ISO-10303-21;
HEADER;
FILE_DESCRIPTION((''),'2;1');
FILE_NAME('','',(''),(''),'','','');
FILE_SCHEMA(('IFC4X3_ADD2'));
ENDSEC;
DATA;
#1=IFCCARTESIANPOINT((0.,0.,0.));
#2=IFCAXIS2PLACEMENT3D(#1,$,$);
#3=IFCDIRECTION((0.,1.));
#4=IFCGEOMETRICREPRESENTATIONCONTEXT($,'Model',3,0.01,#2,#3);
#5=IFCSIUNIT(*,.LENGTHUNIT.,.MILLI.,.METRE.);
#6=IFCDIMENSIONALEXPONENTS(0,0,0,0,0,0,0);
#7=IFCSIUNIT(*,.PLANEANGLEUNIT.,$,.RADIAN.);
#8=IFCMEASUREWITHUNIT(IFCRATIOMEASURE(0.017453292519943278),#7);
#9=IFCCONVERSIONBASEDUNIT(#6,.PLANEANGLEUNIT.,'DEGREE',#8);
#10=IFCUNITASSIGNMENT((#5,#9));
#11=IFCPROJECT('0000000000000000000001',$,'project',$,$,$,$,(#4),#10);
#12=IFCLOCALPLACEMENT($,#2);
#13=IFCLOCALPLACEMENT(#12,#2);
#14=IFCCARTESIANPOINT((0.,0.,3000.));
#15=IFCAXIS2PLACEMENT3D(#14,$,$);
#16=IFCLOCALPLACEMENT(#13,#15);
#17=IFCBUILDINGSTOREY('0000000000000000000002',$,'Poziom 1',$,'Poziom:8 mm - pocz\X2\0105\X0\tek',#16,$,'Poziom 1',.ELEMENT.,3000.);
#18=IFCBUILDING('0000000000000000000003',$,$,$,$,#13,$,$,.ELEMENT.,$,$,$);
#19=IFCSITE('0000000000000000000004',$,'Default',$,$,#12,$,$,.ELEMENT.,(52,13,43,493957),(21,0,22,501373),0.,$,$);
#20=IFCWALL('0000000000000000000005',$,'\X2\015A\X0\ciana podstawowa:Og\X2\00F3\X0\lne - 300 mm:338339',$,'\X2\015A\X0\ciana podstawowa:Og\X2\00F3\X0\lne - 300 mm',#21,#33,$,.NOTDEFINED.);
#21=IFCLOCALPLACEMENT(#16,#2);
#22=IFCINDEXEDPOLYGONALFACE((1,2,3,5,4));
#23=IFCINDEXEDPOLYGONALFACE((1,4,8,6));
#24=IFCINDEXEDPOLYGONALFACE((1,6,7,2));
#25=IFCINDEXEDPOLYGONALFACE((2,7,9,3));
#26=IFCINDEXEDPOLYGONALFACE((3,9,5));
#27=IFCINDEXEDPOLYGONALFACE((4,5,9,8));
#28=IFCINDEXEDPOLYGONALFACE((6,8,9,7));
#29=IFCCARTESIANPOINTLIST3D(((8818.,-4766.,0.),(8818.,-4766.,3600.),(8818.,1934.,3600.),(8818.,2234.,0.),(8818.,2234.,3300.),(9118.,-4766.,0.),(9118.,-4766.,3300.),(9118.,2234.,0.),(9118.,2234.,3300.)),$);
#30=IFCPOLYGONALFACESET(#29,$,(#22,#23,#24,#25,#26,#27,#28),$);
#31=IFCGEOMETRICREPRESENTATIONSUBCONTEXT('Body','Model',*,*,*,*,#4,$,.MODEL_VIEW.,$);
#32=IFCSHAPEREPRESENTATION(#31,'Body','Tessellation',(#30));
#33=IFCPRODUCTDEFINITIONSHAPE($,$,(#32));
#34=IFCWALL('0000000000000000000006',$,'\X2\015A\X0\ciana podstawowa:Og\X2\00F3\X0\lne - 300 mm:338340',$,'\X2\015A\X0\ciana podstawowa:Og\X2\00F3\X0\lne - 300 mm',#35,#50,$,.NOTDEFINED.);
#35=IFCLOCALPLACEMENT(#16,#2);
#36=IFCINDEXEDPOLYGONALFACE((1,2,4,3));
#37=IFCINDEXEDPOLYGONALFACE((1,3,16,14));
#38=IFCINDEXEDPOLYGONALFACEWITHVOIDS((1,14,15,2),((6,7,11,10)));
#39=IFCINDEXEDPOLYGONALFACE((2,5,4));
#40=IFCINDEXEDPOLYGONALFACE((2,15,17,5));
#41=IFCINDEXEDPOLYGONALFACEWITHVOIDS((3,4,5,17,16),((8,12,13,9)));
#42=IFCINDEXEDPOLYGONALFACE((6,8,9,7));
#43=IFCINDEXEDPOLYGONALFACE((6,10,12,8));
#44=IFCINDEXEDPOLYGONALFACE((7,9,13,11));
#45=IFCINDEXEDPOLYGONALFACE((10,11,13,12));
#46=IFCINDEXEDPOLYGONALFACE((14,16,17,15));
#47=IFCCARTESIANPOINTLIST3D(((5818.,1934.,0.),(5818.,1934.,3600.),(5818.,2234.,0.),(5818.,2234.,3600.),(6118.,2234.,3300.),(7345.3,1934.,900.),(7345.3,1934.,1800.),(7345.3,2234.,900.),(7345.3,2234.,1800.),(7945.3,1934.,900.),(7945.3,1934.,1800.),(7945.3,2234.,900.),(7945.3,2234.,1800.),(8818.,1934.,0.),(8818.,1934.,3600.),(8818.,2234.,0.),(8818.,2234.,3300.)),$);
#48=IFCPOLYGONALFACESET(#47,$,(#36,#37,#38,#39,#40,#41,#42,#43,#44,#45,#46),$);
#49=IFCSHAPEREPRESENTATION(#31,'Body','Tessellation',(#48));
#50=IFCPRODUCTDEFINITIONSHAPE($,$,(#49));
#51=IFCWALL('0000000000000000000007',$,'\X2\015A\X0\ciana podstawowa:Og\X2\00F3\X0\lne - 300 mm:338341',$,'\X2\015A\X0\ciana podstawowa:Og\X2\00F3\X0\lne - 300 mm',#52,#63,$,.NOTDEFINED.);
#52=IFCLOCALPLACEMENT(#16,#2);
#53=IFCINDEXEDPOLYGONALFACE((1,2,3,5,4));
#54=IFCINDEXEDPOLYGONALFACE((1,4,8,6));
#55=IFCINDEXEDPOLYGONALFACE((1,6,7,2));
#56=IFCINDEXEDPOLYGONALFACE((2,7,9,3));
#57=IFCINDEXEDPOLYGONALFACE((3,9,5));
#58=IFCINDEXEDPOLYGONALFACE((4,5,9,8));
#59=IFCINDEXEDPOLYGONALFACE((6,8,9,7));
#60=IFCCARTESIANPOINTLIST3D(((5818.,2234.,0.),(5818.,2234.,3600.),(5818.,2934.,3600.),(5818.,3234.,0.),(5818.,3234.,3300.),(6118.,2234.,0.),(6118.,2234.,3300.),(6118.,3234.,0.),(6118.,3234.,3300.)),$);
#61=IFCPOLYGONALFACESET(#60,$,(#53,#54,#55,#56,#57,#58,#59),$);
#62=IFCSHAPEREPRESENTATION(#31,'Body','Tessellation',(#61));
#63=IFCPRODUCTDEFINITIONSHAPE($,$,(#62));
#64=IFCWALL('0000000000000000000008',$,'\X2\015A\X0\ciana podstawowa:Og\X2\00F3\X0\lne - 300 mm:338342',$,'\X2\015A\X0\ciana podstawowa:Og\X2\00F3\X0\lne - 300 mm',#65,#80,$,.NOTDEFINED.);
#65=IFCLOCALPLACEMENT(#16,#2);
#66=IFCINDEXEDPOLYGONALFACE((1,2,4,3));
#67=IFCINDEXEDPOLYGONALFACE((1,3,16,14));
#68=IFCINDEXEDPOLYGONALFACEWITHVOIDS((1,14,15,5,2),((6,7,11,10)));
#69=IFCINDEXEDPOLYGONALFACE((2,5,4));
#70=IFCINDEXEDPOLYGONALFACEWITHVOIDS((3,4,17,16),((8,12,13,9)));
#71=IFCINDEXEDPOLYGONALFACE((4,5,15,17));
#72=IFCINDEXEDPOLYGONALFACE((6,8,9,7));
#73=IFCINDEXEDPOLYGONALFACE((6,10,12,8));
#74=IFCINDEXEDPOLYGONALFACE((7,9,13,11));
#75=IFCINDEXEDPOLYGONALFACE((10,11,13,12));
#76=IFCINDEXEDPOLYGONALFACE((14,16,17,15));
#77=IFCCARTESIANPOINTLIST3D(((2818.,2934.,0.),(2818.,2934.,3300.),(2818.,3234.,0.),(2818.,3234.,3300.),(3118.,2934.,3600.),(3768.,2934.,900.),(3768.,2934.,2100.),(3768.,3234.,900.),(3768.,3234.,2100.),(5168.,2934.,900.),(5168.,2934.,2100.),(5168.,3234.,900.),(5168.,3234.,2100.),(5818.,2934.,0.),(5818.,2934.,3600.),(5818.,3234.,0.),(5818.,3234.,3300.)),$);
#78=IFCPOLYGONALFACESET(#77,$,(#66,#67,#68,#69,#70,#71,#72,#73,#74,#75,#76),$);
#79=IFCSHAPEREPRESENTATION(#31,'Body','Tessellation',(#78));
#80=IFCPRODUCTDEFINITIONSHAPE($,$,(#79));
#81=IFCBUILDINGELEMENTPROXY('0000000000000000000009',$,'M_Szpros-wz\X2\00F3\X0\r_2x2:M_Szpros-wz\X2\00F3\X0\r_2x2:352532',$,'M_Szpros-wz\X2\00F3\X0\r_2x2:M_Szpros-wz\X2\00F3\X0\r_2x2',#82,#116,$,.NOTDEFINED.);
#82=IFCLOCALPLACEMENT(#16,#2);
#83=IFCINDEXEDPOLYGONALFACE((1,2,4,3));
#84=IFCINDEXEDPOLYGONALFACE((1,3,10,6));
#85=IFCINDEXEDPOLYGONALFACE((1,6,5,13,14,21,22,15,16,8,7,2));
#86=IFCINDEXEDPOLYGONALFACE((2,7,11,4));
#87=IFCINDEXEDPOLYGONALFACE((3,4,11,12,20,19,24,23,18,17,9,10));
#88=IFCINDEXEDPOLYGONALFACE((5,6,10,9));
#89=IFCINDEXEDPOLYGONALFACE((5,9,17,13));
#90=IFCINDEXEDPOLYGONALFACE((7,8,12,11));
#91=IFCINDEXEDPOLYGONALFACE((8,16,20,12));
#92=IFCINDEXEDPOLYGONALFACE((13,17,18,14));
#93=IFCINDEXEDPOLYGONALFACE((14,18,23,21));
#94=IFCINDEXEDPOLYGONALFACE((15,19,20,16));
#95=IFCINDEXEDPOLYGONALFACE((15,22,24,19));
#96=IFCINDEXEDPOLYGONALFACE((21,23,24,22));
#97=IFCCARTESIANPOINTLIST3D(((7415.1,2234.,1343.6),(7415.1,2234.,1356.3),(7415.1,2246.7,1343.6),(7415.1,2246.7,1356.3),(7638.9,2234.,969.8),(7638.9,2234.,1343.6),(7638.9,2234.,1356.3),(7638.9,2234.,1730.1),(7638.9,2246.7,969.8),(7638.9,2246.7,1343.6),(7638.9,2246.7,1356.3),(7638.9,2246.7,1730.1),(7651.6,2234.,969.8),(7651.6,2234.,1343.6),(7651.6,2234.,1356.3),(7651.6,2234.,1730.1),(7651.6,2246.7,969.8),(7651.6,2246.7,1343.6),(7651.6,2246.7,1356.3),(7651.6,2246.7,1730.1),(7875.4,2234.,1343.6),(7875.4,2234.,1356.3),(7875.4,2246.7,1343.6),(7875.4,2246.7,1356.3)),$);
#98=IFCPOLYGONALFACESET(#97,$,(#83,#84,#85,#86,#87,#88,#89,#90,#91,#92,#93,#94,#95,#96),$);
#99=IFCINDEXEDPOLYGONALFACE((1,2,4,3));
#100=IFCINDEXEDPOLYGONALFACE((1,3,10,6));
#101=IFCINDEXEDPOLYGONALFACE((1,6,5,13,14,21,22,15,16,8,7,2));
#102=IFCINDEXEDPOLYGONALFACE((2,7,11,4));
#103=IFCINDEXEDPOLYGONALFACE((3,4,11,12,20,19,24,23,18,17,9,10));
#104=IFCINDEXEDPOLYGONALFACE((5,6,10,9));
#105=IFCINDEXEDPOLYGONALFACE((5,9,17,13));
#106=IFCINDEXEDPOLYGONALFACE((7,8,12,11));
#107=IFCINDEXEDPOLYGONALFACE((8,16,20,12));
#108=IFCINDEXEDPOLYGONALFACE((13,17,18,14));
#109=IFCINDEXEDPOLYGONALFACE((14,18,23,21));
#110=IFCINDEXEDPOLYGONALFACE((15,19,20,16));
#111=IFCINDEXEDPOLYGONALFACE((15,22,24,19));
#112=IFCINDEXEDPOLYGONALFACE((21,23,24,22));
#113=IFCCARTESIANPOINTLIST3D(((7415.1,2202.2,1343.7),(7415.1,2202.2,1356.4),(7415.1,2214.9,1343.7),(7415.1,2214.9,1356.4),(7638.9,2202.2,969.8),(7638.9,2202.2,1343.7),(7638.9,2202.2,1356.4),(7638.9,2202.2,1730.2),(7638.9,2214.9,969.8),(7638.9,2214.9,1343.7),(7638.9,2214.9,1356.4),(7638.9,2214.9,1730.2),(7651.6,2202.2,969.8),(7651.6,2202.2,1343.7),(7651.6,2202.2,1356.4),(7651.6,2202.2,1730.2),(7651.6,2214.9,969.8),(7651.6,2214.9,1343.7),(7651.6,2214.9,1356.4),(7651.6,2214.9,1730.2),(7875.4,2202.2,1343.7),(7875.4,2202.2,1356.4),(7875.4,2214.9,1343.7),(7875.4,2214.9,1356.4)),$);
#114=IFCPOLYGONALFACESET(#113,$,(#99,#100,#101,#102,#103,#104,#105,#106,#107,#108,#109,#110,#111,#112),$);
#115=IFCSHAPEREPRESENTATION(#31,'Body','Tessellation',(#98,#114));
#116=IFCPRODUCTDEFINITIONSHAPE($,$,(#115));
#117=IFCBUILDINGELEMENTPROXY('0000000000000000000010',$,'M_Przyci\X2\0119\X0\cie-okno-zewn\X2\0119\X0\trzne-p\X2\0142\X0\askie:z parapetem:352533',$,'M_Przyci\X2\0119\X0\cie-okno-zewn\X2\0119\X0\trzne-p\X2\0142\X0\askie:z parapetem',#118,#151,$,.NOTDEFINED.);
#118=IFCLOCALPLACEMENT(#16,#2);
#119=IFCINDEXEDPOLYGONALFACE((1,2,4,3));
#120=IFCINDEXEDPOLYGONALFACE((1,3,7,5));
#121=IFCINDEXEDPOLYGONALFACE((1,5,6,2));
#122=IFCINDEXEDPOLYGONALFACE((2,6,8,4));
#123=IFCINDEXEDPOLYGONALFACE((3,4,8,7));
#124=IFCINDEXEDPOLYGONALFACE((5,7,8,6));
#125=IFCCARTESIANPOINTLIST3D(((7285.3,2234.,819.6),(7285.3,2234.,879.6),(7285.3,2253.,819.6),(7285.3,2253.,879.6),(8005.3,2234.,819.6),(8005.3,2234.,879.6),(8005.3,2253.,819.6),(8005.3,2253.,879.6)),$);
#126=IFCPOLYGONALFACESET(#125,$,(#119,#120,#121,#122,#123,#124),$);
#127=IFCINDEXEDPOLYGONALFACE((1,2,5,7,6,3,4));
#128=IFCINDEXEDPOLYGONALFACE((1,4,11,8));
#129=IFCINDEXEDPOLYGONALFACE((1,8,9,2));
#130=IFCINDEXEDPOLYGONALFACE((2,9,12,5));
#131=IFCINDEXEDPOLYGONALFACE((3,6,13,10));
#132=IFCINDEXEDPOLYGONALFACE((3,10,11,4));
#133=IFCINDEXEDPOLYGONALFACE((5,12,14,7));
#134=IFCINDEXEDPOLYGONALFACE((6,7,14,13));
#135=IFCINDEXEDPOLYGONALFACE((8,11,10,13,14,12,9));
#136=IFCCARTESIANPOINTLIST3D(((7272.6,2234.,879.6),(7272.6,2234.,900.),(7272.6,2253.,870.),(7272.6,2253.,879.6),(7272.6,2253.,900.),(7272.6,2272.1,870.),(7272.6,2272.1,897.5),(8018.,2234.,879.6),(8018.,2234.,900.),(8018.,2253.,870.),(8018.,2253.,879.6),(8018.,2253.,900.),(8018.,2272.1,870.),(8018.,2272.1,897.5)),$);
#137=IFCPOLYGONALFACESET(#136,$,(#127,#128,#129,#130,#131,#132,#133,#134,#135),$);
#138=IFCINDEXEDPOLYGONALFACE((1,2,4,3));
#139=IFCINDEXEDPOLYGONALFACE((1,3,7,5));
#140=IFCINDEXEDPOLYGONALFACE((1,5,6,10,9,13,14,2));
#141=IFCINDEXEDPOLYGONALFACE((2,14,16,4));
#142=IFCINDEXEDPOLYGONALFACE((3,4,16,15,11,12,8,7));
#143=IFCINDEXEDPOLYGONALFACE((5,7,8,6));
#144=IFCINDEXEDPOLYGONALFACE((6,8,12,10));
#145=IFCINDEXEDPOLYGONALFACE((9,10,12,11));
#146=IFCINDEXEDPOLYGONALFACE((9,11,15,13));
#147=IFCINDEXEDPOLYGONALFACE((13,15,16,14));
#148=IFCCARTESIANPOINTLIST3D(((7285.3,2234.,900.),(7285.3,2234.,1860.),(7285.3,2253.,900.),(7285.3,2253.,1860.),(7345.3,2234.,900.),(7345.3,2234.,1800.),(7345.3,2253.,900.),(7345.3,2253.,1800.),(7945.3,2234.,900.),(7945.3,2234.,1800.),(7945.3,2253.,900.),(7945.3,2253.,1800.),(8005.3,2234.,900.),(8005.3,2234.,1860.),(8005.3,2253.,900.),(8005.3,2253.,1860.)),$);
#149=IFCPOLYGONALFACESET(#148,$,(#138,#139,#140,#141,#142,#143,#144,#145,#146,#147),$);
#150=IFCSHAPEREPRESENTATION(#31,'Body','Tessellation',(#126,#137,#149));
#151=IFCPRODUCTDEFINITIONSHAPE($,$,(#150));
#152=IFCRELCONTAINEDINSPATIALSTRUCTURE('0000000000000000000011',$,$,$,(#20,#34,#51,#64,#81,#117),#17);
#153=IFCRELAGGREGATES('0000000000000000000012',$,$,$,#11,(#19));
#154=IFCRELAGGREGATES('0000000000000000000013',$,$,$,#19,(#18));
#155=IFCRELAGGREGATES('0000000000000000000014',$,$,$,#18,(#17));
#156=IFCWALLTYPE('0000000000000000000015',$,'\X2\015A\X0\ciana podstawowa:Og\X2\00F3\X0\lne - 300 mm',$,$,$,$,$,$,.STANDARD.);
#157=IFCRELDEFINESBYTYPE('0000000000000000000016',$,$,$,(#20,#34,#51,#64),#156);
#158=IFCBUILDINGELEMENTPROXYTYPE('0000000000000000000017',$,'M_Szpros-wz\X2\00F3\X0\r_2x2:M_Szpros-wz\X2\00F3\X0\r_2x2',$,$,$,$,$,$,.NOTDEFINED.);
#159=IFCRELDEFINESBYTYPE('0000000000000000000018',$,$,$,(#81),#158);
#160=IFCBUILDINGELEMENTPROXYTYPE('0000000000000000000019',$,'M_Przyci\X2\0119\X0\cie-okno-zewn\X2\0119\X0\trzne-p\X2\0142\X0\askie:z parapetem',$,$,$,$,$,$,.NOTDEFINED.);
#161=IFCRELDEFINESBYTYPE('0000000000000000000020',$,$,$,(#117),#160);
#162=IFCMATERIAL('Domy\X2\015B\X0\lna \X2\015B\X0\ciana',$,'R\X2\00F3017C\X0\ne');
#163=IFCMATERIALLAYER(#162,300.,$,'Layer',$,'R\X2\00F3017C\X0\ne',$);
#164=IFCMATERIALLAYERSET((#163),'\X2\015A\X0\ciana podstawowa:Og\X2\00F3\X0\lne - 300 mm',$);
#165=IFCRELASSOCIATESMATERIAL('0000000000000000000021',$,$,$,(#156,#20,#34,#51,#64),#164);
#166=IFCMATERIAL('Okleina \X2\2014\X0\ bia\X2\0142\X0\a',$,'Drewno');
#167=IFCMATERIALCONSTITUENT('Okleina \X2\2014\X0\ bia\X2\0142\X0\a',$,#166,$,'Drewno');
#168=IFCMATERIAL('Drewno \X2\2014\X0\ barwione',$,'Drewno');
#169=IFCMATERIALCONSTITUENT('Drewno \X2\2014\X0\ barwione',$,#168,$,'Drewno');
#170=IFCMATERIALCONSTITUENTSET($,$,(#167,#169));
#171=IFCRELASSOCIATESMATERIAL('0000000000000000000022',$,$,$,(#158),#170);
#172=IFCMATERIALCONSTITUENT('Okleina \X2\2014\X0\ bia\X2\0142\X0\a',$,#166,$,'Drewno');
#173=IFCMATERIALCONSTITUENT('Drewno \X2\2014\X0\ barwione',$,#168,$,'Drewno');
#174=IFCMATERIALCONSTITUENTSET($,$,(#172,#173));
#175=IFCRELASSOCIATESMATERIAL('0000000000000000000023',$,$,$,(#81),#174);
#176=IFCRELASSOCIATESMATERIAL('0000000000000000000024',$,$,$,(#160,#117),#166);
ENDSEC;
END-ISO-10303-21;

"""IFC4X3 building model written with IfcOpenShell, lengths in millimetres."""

from ifc_helpers import new_model, entity, si_unit, converted_unit, direction, frame, frame_2d, origin, place, context, subcontext, project, spatial, polyline, rectangle, outline, extrude, clip, bounded_halfspace, source, transform, mapped, material, layer, layer_set, constituent, constituent_set, type_object, type_shapes, element, save


model = new_model("IFC4X3")

# Units and contexts
model_context = context("Model", 3, precision=0.01, world=origin(), true_north=direction((0.0, 1.0)))
body_context = subcontext(model_context, "Body", "Model", "MODEL_VIEW")
ifc_project = project(units=[si_unit("LENGTHUNIT", "METRE", prefix="MILLI"), converted_unit("PLANEANGLEUNIT", "DEGREE", entity("IfcRatioMeasure", 0.017453292519943278), si_unit("PLANEANGLEUNIT", "RADIAN"), dimensions=[0, 0, 0, 0, 0, 0, 0])], contexts=[model_context])

# Site, building, storey
site_placement = place(None, origin())
site = spatial("IfcSite", under=ifc_project, at=site_placement, Name="Default", CompositionType="ELEMENT", RefLatitude=(52, 13, 43, 493957), RefLongitude=(21, 0, 22, 501373), RefElevation=0.0)
building_placement = place(site_placement, origin())
building = spatial("IfcBuilding", under=site, at=building_placement, CompositionType="ELEMENT")
storey_placement = place(building_placement, frame((0.0, 0.0, 3000.0)))
storey = spatial("IfcBuildingStorey", under=building, at=storey_placement, Name="Poziom 1", ObjectType="Poziom:8 mm - początek", LongName="Poziom 1", CompositionType="ELEMENT", Elevation=3000.0)

# Wall
ifc_material_1 = material(Name="Domyślna ściana", Category="Różne")
ifc_layer = layer(ifc_material_1, 300.0, Name="Layer", Category="Różne")
ifc_layer_set = layer_set([ifc_layer], Name="Ściana podstawowa:Ogólne - 300 mm")
wall_type = type_object("IfcWallType", Name="Ściana podstawowa:Ogólne - 300 mm", PredefinedType="STANDARD", material=ifc_layer_set)
wall_1_placement = place(storey_placement, frame((8968.0, -4766.0, 0.0), z_axis=(0.0, 0.0, 1.0), x_axis=(0.0, 1.0, 0.0)))
element("IfcWall", 1, at=wall_1_placement, inside=storey, type_object=wall_type, material=ifc_layer_set, Name="Ściana podstawowa:Ogólne - 300 mm:338339", ObjectType="Ściana podstawowa:Ogólne - 300 mm", PredefinedType="NOTDEFINED", context=body_context, shape_type="Clipping", body=[
    clip(clip(extrude(rectangle(XDim=7000.0, YDim=300.0, at=frame_2d((3500.0, 0.0), x_axis=(-1.0, 0.0))), origin(), (0.0, 0.0, 1.0), 3600.0), bounded_halfspace(frame((0.0, -150.0, 3300.0), z_axis=(0.0, -0.707107, 0.707107), x_axis=(1.0, 0.0, 0.0)), False, frame((0.0, -150.0, 3300.0)), polyline([(0.0, 0.0), (7000.0, 0.0), (6700.0, 300.0), (0.0, 300.0), (0.0, 0.0)]))), bounded_halfspace(frame((7000.0, -150.0, 3300.0), z_axis=(0.707107, 0.0, 0.707107), x_axis=(0.0, 1.0, 0.0)), False, frame((7000.0, -150.0, 3300.0)), polyline([(0.0, 0.0), (0.0, 300.0), (-300.0, 300.0), (0.0, 0.0)]))),
])

# Wall, opening
wall_2_placement = place(storey_placement, frame((8818.0, 2084.0, 0.0), z_axis=(0.0, 0.0, 1.0), x_axis=(-1.0, 0.0, 0.0)))
wall_2 = element("IfcWall", 2, at=wall_2_placement, inside=storey, type_object=wall_type, material=ifc_layer_set, Name="Ściana podstawowa:Ogólne - 300 mm:338340", ObjectType="Ściana podstawowa:Ogólne - 300 mm", PredefinedType="NOTDEFINED", context=body_context, shape_type="Clipping", body=[
    clip(clip(extrude(rectangle(XDim=3000.0, YDim=300.0, at=frame_2d((1500.0, 0.0), x_axis=(-1.0, 0.0))), origin(), (0.0, 0.0, 1.0), 3600.0), bounded_halfspace(frame((0.0, -150.0, 3300.0), z_axis=(0.0, -0.707107, 0.707107), x_axis=(1.0, 0.0, 0.0)), False, frame((0.0, -150.0, 3300.0)), polyline([(0.0, 0.0), (2700.0, 0.0), (3000.0, 300.0), (0.0, 300.0), (0.0, 0.0)]))), bounded_halfspace(frame((2700.0, -150.0, 3300.0), z_axis=(-0.707107, 0.0, 0.707107), x_axis=(0.0, -1.0, 0.0)), False, frame((2700.0, -150.0, 3300.0)), polyline([(0.0, 0.0), (300.0, 0.0), (300.0, 300.0), (0.0, 0.0)]))),
])
opening_1_placement = place(wall_2_placement, frame((1472.7, 150.0, 900.0)))
element("IfcOpeningElement", 3, at=opening_1_placement, cuts=wall_2, PredefinedType="OPENING", context=body_context, shape_type="SweptSolid", body=[
    extrude(rectangle(XDim=900.0, YDim=600.0, at=frame_2d((450.0, 300.0), x_axis=(-1.0, 0.0))), frame((0.0, 0.0, 0.0), z_axis=(0.0, -1.0, 0.0), x_axis=(0.0, 0.0, 1.0)), (0.0, 0.0, 1.0), 300.0),
])

# Wall
wall_3_placement = place(storey_placement, frame((5968.0, 2234.0, 0.0), z_axis=(0.0, 0.0, 1.0), x_axis=(0.0, 1.0, 0.0)))
element("IfcWall", 4, at=wall_3_placement, inside=storey, type_object=wall_type, material=ifc_layer_set, Name="Ściana podstawowa:Ogólne - 300 mm:338341", ObjectType="Ściana podstawowa:Ogólne - 300 mm", PredefinedType="NOTDEFINED", context=body_context, shape_type="Clipping", body=[
    clip(clip(extrude(rectangle(XDim=1000.0, YDim=300.0, at=frame_2d((500.0, 0.0), x_axis=(-1.0, 0.0))), origin(), (0.0, 0.0, 1.0), 3600.0), bounded_halfspace(frame((1000.0, -150.0, 3300.0), z_axis=(0.707107, 0.0, 0.707107), x_axis=(0.0, 1.0, 0.0)), False, frame((1000.0, -150.0, 3300.0)), polyline([(0.0, 0.0), (0.0, 300.0), (-300.0, 300.0), (0.0, 0.0)]))), bounded_halfspace(frame((0.0, -150.0, 3300.0), z_axis=(0.0, -0.707107, 0.707107), x_axis=(1.0, 0.0, 0.0)), False, frame((0.0, -150.0, 3300.0)), polyline([(0.0, 0.0), (1000.0, 0.0), (700.0, 300.0), (0.0, 300.0), (0.0, 0.0)]))),
])

# Wall, opening
wall_4_placement = place(storey_placement, frame((5818.0, 3084.0, 0.0), z_axis=(0.0, 0.0, 1.0), x_axis=(-1.0, 0.0, 0.0)))
wall_4 = element("IfcWall", 5, at=wall_4_placement, inside=storey, type_object=wall_type, material=ifc_layer_set, Name="Ściana podstawowa:Ogólne - 300 mm:338342", ObjectType="Ściana podstawowa:Ogólne - 300 mm", PredefinedType="NOTDEFINED", context=body_context, shape_type="Clipping", body=[
    clip(clip(extrude(rectangle(XDim=3000.0, YDim=300.0, at=frame_2d((1500.0, 0.0), x_axis=(-1.0, 0.0))), origin(), (0.0, 0.0, 1.0), 3600.0), bounded_halfspace(frame((3000.0, -150.0, 3300.0), z_axis=(0.707107, 0.0, 0.707107), x_axis=(0.0, 1.0, 0.0)), False, frame((3000.0, -150.0, 3300.0)), polyline([(0.0, 0.0), (0.0, 300.0), (-300.0, 300.0), (0.0, 0.0)]))), bounded_halfspace(frame((0.0, -150.0, 3300.0), z_axis=(0.0, -0.707107, 0.707107), x_axis=(1.0, 0.0, 0.0)), False, frame((0.0, -150.0, 3300.0)), polyline([(0.0, 0.0), (3000.0, 0.0), (2700.0, 300.0), (0.0, 300.0), (0.0, 0.0)]))),
])
opening_2_placement = place(wall_4_placement, frame((2050.0, 150.0, 900.0)))
element("IfcOpeningElement", 6, at=opening_2_placement, cuts=wall_4, PredefinedType="OPENING", context=body_context, shape_type="SweptSolid", body=[
    extrude(rectangle(XDim=1200.0, YDim=1400.0, at=frame_2d((600.0, 700.0), x_axis=(-1.0, 0.0))), frame((0.0, 0.0, 0.0), z_axis=(0.0, -1.0, 0.0), x_axis=(0.0, 0.0, 1.0)), (0.0, 0.0, 1.0), 300.0),
])

# Building element proxies
ifc_material_2 = material(Name="Okleina — biała", Category="Drewno")
ifc_constituent_1 = constituent(ifc_material_2, Name="Okleina — biała", Category="Drewno")
ifc_material_3 = material(Name="Drewno — barwione", Category="Drewno")
ifc_constituent_2 = constituent(ifc_material_3, Name="Drewno — barwione", Category="Drewno")
ifc_constituent_set_1 = constituent_set(constituents=[ifc_constituent_1, ifc_constituent_2])
ifc_constituent_3 = constituent(ifc_material_2, Name="Okleina — biała", Category="Drewno")
ifc_constituent_4 = constituent(ifc_material_3, Name="Drewno — barwione", Category="Drewno")
ifc_constituent_set_2 = constituent_set(constituents=[ifc_constituent_3, ifc_constituent_4])
building_element_proxy_type_1 = type_object("IfcBuildingElementProxyType", Name="M_Szpros-wzór_2x2:M_Szpros-wzór_2x2", PredefinedType="NOTDEFINED", material=ifc_constituent_set_2)
shared_shape_1 = source(origin(), body_context, "Body", "SweptSolid", [
    extrude(outline(polyline([(6.4, -6.4), (380.1, -6.4), (380.1, 6.3), (6.4, 6.3), (6.4, 230.2), (-6.3, 230.2), (-6.3, 6.3), (-380.2, 6.3), (-380.2, -6.4), (-6.3, -6.4), (-6.3, -230.1), (6.4, -230.1), (6.4, -6.4)])), frame((0.0, 9.5, 380.1), z_axis=(0.0, 1.0, 0.0), x_axis=(0.0, 0.0, 1.0)), (0.0, 0.0, 1.0), 12.7),
    extrude(outline(polyline([(6.4, -6.4), (380.2, -6.4), (380.2, 6.3), (6.4, 6.3), (6.4, 230.2), (-6.3, 230.2), (-6.3, 6.3), (-380.2, 6.3), (-380.2, -6.4), (-6.3, -6.4), (-6.3, -230.1), (6.4, -230.1), (6.4, -6.4)])), frame((0.0, -22.2, 380.2), z_axis=(0.0, 1.0, 0.0), x_axis=(0.0, 0.0, 1.0)), (0.0, 0.0, 1.0), 12.7),
])
type_shapes(building_element_proxy_type_1, [shared_shape_1])
proxy_1_placement = place(storey_placement, frame((7645.3, 2224.5, 969.8)))
element("IfcBuildingElementProxy", 7, at=proxy_1_placement, inside=storey, type_object=building_element_proxy_type_1, material=ifc_constituent_set_1, Name="M_Szpros-wzór_2x2:M_Szpros-wzór_2x2:352532", ObjectType="M_Szpros-wzór_2x2:M_Szpros-wzór_2x2", PredefinedType="NOTDEFINED", context=body_context, shape_type="MappedRepresentation", body=[
    mapped(shared_shape_1, transform((0.0, 0.0, 0.0), scale=1.0)),
])
building_element_proxy_type_2 = type_object("IfcBuildingElementProxyType", Name="M_Przycięcie-okno-zewnętrzne-płaskie:z parapetem", PredefinedType="NOTDEFINED", material=ifc_material_2)
shared_shape_2 = source(origin(), body_context, "Body", "SweptSolid", [
    extrude(rectangle(XDim=720.0, YDim=60.0, at=frame_2d((0.0, 0.0), x_axis=(1.0, 0.0))), frame((0.0, -950.4, 0.0), z_axis=(0.0, 0.0, 1.0), x_axis=(-1.0, 0.0, 0.0)), (0.0, 0.0, 1.0), 19.0),
    extrude(outline(polyline([(-19.0, -15.2), (0.0, -15.2), (0.0, -5.7), (19.0, -5.7), (19.0, 14.8), (0.0, 14.8), (-19.0, 12.3), (-19.0, -15.2)])), frame((-372.7, -914.8, 19.0), z_axis=(1.0, 0.0, 0.0), x_axis=(0.0, 0.0, -1.0)), (0.0, 0.0, 1.0), 745.4),
    extrude(outline(polyline([(-495.0, -360.0), (465.0, -360.0), (465.0, -300.0), (-435.0, -300.0), (-435.0, 300.0), (465.0, 300.0), (465.0, 360.0), (-495.0, 360.0), (-495.0, -360.0)])), frame((0.0, -435.0, 0.0), z_axis=(0.0, 0.0, 1.0), x_axis=(0.0, -1.0, 0.0)), (0.0, 0.0, 1.0), 19.0),
])
type_shapes(building_element_proxy_type_2, [shared_shape_2])
proxy_2_placement = place(storey_placement, frame((7645.3, 2234.0, 1800.0), z_axis=(0.0, 1.0, 0.0), x_axis=(-1.0, 0.0, 0.0)))
element("IfcBuildingElementProxy", 8, at=proxy_2_placement, inside=storey, type_object=building_element_proxy_type_2, material=ifc_material_2, Name="M_Przycięcie-okno-zewnętrzne-płaskie:z parapetem:352533", ObjectType="M_Przycięcie-okno-zewnętrzne-płaskie:z parapetem", PredefinedType="NOTDEFINED", context=body_context, shape_type="MappedRepresentation", body=[
    mapped(shared_shape_2, transform((0.0, 0.0, 0.0), scale=1.0)),
])

save(model, "model.ifc")
